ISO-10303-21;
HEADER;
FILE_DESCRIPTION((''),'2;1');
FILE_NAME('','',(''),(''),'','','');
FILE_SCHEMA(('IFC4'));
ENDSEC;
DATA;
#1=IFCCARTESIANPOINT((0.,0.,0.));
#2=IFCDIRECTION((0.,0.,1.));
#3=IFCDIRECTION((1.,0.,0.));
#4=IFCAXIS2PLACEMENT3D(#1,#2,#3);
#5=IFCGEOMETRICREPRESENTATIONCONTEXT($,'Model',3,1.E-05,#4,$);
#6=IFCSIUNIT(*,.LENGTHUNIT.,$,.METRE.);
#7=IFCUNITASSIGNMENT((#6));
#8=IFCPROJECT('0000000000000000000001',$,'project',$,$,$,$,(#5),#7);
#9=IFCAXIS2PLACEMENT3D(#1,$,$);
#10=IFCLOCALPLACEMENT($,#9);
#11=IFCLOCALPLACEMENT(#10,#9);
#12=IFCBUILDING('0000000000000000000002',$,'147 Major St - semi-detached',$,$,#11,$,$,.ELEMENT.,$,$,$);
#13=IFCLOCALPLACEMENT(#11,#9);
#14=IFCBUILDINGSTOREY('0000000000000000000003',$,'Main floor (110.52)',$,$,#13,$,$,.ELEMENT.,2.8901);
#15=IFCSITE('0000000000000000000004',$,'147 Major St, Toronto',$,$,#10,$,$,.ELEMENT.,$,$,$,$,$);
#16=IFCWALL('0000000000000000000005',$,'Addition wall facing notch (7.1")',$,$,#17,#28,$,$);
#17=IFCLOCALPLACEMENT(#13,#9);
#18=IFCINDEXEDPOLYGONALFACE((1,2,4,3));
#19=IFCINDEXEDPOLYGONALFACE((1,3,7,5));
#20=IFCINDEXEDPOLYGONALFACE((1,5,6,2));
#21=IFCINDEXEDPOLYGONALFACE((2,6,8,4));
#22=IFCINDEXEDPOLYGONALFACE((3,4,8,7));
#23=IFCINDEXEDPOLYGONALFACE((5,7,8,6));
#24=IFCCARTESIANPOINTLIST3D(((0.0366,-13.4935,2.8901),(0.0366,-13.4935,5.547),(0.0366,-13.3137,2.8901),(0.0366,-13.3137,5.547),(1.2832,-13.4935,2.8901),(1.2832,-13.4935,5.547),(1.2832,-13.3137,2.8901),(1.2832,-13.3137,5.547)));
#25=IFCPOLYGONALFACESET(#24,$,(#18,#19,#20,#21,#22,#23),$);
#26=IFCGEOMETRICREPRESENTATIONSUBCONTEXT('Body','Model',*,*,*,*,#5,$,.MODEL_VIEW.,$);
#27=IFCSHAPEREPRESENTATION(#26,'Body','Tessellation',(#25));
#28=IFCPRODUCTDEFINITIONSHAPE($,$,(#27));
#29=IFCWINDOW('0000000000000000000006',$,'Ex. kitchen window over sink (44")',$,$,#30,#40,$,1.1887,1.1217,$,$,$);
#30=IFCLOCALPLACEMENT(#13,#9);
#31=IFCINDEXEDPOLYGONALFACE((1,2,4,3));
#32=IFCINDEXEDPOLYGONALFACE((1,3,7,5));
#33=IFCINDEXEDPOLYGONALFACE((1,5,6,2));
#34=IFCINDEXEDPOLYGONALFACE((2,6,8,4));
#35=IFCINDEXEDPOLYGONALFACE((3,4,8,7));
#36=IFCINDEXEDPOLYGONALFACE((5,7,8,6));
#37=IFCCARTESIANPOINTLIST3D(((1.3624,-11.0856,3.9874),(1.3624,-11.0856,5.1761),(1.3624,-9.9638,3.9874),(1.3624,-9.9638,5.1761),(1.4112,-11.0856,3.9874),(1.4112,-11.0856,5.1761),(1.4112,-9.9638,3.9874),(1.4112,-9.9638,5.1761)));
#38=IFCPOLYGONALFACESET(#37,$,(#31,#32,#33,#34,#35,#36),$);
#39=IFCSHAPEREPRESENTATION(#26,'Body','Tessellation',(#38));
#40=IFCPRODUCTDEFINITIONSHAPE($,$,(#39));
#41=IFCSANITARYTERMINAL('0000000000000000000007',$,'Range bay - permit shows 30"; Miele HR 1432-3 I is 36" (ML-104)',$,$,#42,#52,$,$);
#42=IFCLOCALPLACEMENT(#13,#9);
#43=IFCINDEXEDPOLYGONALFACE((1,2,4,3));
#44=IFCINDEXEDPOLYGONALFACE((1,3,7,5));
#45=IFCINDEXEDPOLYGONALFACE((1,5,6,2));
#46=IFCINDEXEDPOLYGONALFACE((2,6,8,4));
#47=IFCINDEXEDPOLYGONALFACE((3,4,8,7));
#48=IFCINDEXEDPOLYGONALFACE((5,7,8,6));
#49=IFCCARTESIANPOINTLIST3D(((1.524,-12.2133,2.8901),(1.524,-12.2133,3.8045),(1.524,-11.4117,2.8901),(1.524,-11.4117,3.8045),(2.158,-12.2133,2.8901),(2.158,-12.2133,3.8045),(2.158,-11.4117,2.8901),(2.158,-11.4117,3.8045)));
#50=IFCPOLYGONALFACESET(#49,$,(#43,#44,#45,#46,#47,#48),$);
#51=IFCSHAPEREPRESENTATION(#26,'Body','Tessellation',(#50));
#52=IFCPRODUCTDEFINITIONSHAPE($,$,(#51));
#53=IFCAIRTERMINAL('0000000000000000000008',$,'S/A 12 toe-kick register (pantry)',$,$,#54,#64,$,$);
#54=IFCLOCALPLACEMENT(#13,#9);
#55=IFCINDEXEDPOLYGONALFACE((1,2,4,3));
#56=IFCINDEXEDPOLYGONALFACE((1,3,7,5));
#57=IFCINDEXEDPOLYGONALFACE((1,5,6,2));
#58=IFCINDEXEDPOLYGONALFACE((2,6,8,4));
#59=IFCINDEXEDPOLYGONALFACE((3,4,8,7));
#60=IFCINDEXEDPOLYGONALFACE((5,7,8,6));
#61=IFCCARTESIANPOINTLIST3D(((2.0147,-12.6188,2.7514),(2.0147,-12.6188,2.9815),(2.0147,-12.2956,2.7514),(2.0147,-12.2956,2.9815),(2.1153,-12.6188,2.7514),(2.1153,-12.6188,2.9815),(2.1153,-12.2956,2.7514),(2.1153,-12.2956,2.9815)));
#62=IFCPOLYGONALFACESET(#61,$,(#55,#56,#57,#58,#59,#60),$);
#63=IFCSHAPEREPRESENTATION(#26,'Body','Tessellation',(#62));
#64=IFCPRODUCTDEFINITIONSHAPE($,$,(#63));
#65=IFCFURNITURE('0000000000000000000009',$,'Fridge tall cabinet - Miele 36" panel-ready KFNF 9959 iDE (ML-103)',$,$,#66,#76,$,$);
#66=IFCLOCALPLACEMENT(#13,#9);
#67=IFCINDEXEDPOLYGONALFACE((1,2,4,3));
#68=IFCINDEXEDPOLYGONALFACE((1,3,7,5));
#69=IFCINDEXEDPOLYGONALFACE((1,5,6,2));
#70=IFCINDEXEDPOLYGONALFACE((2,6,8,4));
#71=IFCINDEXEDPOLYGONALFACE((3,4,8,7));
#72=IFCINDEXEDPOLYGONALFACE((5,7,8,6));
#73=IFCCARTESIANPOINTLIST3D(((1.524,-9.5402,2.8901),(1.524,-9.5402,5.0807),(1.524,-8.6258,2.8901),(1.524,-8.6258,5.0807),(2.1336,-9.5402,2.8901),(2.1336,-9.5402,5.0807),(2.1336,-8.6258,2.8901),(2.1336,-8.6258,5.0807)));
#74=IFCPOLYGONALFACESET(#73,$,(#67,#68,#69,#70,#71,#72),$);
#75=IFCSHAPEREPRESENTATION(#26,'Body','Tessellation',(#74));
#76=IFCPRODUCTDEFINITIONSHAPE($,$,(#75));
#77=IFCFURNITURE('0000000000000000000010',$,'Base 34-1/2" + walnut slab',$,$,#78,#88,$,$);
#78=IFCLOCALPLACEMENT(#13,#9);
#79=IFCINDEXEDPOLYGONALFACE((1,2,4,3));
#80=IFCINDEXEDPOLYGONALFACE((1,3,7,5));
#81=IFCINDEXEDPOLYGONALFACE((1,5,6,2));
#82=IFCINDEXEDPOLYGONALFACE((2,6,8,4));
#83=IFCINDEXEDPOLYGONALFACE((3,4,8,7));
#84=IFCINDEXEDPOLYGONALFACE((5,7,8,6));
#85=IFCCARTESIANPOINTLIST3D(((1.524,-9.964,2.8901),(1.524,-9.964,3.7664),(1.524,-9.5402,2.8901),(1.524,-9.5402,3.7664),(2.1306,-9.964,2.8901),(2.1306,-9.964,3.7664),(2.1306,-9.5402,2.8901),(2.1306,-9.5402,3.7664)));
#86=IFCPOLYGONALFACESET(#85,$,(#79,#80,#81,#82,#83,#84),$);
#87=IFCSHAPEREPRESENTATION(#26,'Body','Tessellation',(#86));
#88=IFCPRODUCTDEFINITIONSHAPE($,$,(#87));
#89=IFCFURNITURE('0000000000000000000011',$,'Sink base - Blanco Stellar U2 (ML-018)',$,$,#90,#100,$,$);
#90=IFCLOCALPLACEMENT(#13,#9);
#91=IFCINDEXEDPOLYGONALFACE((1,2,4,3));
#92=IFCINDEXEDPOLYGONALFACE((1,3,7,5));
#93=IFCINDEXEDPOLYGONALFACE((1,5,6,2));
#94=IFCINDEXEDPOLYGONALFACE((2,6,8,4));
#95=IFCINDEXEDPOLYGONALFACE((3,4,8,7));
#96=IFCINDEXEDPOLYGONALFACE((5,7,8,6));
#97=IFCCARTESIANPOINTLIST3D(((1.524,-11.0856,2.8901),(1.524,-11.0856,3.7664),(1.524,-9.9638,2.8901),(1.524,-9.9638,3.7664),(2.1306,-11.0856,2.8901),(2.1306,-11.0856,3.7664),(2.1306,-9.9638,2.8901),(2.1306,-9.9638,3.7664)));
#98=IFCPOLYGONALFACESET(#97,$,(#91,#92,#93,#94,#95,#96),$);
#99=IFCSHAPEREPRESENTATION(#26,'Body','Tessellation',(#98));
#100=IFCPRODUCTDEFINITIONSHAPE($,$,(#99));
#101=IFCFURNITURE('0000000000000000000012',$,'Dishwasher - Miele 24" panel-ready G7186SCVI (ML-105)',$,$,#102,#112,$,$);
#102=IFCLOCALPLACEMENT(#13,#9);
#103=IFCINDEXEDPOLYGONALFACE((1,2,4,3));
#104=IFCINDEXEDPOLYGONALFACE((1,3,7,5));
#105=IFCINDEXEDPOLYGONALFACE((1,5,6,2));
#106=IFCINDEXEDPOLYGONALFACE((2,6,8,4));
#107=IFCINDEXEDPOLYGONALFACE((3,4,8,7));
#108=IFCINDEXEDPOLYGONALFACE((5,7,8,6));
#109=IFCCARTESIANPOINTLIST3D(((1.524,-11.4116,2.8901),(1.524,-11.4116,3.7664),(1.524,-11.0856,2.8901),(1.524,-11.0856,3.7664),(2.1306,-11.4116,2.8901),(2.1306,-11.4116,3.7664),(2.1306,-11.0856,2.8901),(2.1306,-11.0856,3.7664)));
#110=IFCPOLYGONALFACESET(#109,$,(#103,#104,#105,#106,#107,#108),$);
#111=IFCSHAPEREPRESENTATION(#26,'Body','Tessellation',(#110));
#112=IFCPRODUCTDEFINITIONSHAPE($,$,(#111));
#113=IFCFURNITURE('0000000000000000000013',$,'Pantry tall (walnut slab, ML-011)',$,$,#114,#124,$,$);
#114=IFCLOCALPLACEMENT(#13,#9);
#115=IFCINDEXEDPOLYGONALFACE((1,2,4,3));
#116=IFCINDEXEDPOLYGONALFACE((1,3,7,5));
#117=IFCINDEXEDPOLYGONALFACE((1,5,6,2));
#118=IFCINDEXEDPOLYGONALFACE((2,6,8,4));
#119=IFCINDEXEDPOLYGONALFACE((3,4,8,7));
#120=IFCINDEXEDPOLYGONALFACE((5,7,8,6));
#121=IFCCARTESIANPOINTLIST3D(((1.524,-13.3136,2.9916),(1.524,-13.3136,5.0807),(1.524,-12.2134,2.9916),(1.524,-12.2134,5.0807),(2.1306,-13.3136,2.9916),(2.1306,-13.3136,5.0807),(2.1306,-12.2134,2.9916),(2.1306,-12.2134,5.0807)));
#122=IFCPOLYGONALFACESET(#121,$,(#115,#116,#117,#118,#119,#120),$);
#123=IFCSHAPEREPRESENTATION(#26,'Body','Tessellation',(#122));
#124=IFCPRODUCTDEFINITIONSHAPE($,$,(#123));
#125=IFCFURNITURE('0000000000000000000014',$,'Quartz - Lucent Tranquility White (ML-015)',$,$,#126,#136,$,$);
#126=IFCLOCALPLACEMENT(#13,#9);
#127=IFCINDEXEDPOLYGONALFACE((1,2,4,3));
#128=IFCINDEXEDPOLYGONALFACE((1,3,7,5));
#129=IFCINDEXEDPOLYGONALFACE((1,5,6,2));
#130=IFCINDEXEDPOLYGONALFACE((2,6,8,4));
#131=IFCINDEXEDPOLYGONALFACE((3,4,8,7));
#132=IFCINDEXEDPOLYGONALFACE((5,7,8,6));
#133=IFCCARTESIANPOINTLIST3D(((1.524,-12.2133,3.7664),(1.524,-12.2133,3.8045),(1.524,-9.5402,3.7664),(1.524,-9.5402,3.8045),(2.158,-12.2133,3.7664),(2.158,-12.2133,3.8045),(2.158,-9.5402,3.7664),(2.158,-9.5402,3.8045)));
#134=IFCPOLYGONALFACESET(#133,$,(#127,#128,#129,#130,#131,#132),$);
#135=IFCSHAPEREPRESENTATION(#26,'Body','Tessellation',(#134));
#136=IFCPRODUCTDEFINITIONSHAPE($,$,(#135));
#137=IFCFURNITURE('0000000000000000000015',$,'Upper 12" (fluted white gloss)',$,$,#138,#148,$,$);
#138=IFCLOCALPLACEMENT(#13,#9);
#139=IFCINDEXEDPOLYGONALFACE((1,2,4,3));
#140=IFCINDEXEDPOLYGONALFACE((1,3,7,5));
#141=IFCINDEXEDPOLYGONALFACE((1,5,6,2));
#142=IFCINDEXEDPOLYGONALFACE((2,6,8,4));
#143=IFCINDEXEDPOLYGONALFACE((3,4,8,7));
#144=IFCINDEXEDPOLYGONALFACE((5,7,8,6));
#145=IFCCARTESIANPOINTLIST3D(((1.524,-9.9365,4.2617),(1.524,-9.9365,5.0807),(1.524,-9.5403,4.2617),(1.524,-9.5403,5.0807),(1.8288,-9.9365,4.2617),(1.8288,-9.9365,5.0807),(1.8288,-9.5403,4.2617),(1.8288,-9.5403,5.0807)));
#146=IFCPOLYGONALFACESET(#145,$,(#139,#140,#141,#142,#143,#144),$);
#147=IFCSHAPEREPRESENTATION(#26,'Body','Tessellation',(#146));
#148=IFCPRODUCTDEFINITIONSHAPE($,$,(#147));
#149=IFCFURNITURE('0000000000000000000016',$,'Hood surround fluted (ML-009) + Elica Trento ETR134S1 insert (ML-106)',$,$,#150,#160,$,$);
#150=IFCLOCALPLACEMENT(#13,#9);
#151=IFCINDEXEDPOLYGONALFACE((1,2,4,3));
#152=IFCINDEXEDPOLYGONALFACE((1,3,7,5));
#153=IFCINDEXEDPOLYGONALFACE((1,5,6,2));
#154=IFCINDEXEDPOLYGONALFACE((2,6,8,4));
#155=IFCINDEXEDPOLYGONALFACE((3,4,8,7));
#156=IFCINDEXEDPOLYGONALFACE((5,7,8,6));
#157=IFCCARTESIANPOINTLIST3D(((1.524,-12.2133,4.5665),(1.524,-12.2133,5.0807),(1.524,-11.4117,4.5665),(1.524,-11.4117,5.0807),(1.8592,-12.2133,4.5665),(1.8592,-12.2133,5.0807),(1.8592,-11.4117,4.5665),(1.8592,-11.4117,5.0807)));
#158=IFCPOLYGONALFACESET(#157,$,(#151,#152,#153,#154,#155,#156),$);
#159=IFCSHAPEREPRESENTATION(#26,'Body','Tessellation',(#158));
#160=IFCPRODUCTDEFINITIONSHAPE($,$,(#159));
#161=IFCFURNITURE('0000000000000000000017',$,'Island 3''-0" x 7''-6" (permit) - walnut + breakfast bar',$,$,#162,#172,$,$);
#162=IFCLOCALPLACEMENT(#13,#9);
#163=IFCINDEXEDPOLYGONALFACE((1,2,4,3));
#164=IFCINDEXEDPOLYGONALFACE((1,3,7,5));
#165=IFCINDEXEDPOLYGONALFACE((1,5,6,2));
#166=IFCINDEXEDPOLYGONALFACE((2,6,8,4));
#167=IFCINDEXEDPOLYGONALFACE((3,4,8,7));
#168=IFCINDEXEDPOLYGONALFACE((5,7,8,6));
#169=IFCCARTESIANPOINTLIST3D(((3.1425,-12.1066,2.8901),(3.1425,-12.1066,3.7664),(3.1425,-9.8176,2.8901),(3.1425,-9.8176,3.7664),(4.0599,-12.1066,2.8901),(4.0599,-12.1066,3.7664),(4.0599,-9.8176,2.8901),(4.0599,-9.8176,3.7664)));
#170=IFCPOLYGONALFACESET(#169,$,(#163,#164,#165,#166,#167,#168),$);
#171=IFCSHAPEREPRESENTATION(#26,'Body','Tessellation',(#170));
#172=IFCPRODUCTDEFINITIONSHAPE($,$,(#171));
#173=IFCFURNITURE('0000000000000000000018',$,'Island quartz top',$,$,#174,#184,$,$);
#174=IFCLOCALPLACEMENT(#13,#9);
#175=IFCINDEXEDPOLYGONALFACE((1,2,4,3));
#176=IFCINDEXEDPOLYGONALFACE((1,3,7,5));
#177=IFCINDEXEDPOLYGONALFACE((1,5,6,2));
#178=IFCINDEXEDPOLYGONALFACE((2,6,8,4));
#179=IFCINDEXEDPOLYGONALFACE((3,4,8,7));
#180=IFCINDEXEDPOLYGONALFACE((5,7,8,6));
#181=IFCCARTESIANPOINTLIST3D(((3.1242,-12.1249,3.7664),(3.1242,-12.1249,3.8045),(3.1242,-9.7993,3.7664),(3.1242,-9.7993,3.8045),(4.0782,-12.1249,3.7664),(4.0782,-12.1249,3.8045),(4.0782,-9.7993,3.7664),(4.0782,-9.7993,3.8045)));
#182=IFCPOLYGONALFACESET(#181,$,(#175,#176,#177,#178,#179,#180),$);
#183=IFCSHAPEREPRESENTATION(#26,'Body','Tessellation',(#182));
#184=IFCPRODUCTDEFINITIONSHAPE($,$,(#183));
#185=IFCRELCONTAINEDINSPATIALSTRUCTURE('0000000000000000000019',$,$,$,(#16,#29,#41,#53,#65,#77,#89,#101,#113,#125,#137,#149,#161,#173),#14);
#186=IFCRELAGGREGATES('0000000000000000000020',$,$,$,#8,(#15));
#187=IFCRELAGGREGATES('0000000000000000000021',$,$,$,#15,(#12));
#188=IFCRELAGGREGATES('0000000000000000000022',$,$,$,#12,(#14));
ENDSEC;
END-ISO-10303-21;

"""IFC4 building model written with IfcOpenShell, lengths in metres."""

from ifc_helpers import new_model, si_unit, frame, origin, origin_with_axes, place, context, subcontext, project, spatial, rectangle, extrude, element, save


model = new_model("IFC4")

# Units and contexts
model_context = context("Model", 3, precision=1e-05, world=origin_with_axes())
body_context = subcontext(model_context, "Body", "Model", "MODEL_VIEW")
ifc_project = project(units=[si_unit("LENGTHUNIT", "METRE")], contexts=[model_context])

# Site, building, storey
site_placement = place(None, origin())
site = spatial("IfcSite", under=ifc_project, at=site_placement, Name="147 Major St, Toronto", CompositionType="ELEMENT")
building_placement = place(site_placement, origin())
building = spatial("IfcBuilding", under=site, at=building_placement, Name="147 Major St - semi-detached", CompositionType="ELEMENT")
storey_placement = place(building_placement, origin())
storey = spatial("IfcBuildingStorey", under=building, at=storey_placement, Name="Main floor (110.52)", CompositionType="ELEMENT", Elevation=2.8901)

# Wall
wall_1_placement = place(storey_placement, frame((0.6599, -13.4036, 2.8901)))
element("IfcWall", 1, at=wall_1_placement, inside=storey, Name="Addition wall facing notch (7.1\")", context=body_context, shape_type="SweptSolid", body=[
    extrude(rectangle(XDim=1.2466, YDim=0.1798), origin_with_axes(), (0.0, 0.0, 1.0), 2.6569),
])

# Window
window_placement = place(storey_placement, frame((1.3868, -10.5247, 3.9874)))
element("IfcWindow", 2, at=window_placement, inside=storey, Name="Ex. kitchen window over sink (44\")", OverallHeight=1.1887, OverallWidth=1.1217, context=body_context, shape_type="SweptSolid", body=[
    extrude(rectangle(XDim=0.0488, YDim=1.1217), origin_with_axes(), (0.0, 0.0, 1.0), 1.1887),
])

# Sanitary terminal
sanitary_terminal_placement = place(storey_placement, frame((1.841, -11.8125, 2.8901)))
element("IfcSanitaryTerminal", 3, at=sanitary_terminal_placement, inside=storey, Name="Range bay - permit shows 30\"; Miele HR 1432-3 I is 36\" (ML-104)", context=body_context, shape_type="SweptSolid", body=[
    extrude(rectangle(XDim=0.634, YDim=0.8016), origin_with_axes(), (0.0, 0.0, 1.0), 0.9144),
])

# Air terminal
air_terminal_placement = place(storey_placement, frame((2.065, -12.4572, 2.7514)))
element("IfcAirTerminal", 4, at=air_terminal_placement, inside=storey, Name="S/A 12 toe-kick register (pantry)", context=body_context, shape_type="SweptSolid", body=[
    extrude(rectangle(XDim=0.1006, YDim=0.3231), origin_with_axes(), (0.0, 0.0, 1.0), 0.2301),
])

# Furniture
furniture_1_placement = place(storey_placement, frame((1.8288, -9.083, 2.8901)))
element("IfcFurniture", 5, at=furniture_1_placement, inside=storey, Name="Fridge tall cabinet - Miele 36\" panel-ready KFNF 9959 iDE (ML-103)", context=body_context, shape_type="SweptSolid", body=[
    extrude(rectangle(XDim=0.6096, YDim=0.9144), origin_with_axes(), (0.0, 0.0, 1.0), 2.1906),
])
furniture_2_placement = place(storey_placement, frame((1.8273, -9.7521, 2.8901)))
element("IfcFurniture", 6, at=furniture_2_placement, inside=storey, Name="Base 34-1/2\" + walnut slab", context=body_context, shape_type="SweptSolid", body=[
    extrude(rectangle(XDim=0.6066, YDim=0.4237), origin_with_axes(), (0.0, 0.0, 1.0), 0.8763),
])
furniture_3_placement = place(storey_placement, frame((1.8273, -10.5247, 2.8901)))
element("IfcFurniture", 7, at=furniture_3_placement, inside=storey, Name="Sink base - Blanco Stellar U2 (ML-018)", context=body_context, shape_type="SweptSolid", body=[
    extrude(rectangle(XDim=0.6066, YDim=1.1217), origin_with_axes(), (0.0, 0.0, 1.0), 0.8763),
])
furniture_4_placement = place(storey_placement, frame((1.8273, -11.2486, 2.8901)))
element("IfcFurniture", 8, at=furniture_4_placement, inside=storey, Name="Dishwasher - Miele 24\" panel-ready G7186SCVI (ML-105)", context=body_context, shape_type="SweptSolid", body=[
    extrude(rectangle(XDim=0.6066, YDim=0.3261), origin_with_axes(), (0.0, 0.0, 1.0), 0.8763),
])
furniture_5_placement = place(storey_placement, frame((1.8273, -12.7635, 2.9916)))
element("IfcFurniture", 9, at=furniture_5_placement, inside=storey, Name="Pantry tall (walnut slab, ML-011)", context=body_context, shape_type="SweptSolid", body=[
    extrude(rectangle(XDim=0.6066, YDim=1.1003), origin_with_axes(), (0.0, 0.0, 1.0), 2.0891),
])
furniture_6_placement = place(storey_placement, frame((1.841, -10.8768, 3.7664)))
element("IfcFurniture", 10, at=furniture_6_placement, inside=storey, Name="Quartz - Lucent Tranquility White (ML-015)", context=body_context, shape_type="SweptSolid", body=[
    extrude(rectangle(XDim=0.634, YDim=2.6731), origin_with_axes(), (0.0, 0.0, 1.0), 0.0381),
])
furniture_7_placement = place(storey_placement, frame((1.6764, -9.7384, 4.2617)))
element("IfcFurniture", 11, at=furniture_7_placement, inside=storey, Name="Upper 12\" (fluted white gloss)", context=body_context, shape_type="SweptSolid", body=[
    extrude(rectangle(XDim=0.3048, YDim=0.3962), origin_with_axes(), (0.0, 0.0, 1.0), 0.819),
])
furniture_8_placement = place(storey_placement, frame((1.6916, -11.8125, 4.5665)))
element("IfcFurniture", 12, at=furniture_8_placement, inside=storey, Name="Hood surround fluted (ML-009) + Elica Trento ETR134S1 insert (ML-106)", context=body_context, shape_type="SweptSolid", body=[
    extrude(rectangle(XDim=0.3353, YDim=0.8016), origin_with_axes(), (0.0, 0.0, 1.0), 0.5142),
])
furniture_9_placement = place(storey_placement, frame((3.6012, -10.9621, 2.8901)))
element("IfcFurniture", 13, at=furniture_9_placement, inside=storey, Name="Island 3'-0\" x 7'-6\" (permit) - walnut + breakfast bar", context=body_context, shape_type="SweptSolid", body=[
    extrude(rectangle(XDim=0.9174, YDim=2.289), origin_with_axes(), (0.0, 0.0, 1.0), 0.8763),
])
furniture_10_placement = place(storey_placement, frame((3.6012, -10.9621, 3.7664)))
element("IfcFurniture", 14, at=furniture_10_placement, inside=storey, Name="Island quartz top", context=body_context, shape_type="SweptSolid", body=[
    extrude(rectangle(XDim=0.954, YDim=2.3256), origin_with_axes(), (0.0, 0.0, 1.0), 0.0381),
])

save(model, "model.ifc")
